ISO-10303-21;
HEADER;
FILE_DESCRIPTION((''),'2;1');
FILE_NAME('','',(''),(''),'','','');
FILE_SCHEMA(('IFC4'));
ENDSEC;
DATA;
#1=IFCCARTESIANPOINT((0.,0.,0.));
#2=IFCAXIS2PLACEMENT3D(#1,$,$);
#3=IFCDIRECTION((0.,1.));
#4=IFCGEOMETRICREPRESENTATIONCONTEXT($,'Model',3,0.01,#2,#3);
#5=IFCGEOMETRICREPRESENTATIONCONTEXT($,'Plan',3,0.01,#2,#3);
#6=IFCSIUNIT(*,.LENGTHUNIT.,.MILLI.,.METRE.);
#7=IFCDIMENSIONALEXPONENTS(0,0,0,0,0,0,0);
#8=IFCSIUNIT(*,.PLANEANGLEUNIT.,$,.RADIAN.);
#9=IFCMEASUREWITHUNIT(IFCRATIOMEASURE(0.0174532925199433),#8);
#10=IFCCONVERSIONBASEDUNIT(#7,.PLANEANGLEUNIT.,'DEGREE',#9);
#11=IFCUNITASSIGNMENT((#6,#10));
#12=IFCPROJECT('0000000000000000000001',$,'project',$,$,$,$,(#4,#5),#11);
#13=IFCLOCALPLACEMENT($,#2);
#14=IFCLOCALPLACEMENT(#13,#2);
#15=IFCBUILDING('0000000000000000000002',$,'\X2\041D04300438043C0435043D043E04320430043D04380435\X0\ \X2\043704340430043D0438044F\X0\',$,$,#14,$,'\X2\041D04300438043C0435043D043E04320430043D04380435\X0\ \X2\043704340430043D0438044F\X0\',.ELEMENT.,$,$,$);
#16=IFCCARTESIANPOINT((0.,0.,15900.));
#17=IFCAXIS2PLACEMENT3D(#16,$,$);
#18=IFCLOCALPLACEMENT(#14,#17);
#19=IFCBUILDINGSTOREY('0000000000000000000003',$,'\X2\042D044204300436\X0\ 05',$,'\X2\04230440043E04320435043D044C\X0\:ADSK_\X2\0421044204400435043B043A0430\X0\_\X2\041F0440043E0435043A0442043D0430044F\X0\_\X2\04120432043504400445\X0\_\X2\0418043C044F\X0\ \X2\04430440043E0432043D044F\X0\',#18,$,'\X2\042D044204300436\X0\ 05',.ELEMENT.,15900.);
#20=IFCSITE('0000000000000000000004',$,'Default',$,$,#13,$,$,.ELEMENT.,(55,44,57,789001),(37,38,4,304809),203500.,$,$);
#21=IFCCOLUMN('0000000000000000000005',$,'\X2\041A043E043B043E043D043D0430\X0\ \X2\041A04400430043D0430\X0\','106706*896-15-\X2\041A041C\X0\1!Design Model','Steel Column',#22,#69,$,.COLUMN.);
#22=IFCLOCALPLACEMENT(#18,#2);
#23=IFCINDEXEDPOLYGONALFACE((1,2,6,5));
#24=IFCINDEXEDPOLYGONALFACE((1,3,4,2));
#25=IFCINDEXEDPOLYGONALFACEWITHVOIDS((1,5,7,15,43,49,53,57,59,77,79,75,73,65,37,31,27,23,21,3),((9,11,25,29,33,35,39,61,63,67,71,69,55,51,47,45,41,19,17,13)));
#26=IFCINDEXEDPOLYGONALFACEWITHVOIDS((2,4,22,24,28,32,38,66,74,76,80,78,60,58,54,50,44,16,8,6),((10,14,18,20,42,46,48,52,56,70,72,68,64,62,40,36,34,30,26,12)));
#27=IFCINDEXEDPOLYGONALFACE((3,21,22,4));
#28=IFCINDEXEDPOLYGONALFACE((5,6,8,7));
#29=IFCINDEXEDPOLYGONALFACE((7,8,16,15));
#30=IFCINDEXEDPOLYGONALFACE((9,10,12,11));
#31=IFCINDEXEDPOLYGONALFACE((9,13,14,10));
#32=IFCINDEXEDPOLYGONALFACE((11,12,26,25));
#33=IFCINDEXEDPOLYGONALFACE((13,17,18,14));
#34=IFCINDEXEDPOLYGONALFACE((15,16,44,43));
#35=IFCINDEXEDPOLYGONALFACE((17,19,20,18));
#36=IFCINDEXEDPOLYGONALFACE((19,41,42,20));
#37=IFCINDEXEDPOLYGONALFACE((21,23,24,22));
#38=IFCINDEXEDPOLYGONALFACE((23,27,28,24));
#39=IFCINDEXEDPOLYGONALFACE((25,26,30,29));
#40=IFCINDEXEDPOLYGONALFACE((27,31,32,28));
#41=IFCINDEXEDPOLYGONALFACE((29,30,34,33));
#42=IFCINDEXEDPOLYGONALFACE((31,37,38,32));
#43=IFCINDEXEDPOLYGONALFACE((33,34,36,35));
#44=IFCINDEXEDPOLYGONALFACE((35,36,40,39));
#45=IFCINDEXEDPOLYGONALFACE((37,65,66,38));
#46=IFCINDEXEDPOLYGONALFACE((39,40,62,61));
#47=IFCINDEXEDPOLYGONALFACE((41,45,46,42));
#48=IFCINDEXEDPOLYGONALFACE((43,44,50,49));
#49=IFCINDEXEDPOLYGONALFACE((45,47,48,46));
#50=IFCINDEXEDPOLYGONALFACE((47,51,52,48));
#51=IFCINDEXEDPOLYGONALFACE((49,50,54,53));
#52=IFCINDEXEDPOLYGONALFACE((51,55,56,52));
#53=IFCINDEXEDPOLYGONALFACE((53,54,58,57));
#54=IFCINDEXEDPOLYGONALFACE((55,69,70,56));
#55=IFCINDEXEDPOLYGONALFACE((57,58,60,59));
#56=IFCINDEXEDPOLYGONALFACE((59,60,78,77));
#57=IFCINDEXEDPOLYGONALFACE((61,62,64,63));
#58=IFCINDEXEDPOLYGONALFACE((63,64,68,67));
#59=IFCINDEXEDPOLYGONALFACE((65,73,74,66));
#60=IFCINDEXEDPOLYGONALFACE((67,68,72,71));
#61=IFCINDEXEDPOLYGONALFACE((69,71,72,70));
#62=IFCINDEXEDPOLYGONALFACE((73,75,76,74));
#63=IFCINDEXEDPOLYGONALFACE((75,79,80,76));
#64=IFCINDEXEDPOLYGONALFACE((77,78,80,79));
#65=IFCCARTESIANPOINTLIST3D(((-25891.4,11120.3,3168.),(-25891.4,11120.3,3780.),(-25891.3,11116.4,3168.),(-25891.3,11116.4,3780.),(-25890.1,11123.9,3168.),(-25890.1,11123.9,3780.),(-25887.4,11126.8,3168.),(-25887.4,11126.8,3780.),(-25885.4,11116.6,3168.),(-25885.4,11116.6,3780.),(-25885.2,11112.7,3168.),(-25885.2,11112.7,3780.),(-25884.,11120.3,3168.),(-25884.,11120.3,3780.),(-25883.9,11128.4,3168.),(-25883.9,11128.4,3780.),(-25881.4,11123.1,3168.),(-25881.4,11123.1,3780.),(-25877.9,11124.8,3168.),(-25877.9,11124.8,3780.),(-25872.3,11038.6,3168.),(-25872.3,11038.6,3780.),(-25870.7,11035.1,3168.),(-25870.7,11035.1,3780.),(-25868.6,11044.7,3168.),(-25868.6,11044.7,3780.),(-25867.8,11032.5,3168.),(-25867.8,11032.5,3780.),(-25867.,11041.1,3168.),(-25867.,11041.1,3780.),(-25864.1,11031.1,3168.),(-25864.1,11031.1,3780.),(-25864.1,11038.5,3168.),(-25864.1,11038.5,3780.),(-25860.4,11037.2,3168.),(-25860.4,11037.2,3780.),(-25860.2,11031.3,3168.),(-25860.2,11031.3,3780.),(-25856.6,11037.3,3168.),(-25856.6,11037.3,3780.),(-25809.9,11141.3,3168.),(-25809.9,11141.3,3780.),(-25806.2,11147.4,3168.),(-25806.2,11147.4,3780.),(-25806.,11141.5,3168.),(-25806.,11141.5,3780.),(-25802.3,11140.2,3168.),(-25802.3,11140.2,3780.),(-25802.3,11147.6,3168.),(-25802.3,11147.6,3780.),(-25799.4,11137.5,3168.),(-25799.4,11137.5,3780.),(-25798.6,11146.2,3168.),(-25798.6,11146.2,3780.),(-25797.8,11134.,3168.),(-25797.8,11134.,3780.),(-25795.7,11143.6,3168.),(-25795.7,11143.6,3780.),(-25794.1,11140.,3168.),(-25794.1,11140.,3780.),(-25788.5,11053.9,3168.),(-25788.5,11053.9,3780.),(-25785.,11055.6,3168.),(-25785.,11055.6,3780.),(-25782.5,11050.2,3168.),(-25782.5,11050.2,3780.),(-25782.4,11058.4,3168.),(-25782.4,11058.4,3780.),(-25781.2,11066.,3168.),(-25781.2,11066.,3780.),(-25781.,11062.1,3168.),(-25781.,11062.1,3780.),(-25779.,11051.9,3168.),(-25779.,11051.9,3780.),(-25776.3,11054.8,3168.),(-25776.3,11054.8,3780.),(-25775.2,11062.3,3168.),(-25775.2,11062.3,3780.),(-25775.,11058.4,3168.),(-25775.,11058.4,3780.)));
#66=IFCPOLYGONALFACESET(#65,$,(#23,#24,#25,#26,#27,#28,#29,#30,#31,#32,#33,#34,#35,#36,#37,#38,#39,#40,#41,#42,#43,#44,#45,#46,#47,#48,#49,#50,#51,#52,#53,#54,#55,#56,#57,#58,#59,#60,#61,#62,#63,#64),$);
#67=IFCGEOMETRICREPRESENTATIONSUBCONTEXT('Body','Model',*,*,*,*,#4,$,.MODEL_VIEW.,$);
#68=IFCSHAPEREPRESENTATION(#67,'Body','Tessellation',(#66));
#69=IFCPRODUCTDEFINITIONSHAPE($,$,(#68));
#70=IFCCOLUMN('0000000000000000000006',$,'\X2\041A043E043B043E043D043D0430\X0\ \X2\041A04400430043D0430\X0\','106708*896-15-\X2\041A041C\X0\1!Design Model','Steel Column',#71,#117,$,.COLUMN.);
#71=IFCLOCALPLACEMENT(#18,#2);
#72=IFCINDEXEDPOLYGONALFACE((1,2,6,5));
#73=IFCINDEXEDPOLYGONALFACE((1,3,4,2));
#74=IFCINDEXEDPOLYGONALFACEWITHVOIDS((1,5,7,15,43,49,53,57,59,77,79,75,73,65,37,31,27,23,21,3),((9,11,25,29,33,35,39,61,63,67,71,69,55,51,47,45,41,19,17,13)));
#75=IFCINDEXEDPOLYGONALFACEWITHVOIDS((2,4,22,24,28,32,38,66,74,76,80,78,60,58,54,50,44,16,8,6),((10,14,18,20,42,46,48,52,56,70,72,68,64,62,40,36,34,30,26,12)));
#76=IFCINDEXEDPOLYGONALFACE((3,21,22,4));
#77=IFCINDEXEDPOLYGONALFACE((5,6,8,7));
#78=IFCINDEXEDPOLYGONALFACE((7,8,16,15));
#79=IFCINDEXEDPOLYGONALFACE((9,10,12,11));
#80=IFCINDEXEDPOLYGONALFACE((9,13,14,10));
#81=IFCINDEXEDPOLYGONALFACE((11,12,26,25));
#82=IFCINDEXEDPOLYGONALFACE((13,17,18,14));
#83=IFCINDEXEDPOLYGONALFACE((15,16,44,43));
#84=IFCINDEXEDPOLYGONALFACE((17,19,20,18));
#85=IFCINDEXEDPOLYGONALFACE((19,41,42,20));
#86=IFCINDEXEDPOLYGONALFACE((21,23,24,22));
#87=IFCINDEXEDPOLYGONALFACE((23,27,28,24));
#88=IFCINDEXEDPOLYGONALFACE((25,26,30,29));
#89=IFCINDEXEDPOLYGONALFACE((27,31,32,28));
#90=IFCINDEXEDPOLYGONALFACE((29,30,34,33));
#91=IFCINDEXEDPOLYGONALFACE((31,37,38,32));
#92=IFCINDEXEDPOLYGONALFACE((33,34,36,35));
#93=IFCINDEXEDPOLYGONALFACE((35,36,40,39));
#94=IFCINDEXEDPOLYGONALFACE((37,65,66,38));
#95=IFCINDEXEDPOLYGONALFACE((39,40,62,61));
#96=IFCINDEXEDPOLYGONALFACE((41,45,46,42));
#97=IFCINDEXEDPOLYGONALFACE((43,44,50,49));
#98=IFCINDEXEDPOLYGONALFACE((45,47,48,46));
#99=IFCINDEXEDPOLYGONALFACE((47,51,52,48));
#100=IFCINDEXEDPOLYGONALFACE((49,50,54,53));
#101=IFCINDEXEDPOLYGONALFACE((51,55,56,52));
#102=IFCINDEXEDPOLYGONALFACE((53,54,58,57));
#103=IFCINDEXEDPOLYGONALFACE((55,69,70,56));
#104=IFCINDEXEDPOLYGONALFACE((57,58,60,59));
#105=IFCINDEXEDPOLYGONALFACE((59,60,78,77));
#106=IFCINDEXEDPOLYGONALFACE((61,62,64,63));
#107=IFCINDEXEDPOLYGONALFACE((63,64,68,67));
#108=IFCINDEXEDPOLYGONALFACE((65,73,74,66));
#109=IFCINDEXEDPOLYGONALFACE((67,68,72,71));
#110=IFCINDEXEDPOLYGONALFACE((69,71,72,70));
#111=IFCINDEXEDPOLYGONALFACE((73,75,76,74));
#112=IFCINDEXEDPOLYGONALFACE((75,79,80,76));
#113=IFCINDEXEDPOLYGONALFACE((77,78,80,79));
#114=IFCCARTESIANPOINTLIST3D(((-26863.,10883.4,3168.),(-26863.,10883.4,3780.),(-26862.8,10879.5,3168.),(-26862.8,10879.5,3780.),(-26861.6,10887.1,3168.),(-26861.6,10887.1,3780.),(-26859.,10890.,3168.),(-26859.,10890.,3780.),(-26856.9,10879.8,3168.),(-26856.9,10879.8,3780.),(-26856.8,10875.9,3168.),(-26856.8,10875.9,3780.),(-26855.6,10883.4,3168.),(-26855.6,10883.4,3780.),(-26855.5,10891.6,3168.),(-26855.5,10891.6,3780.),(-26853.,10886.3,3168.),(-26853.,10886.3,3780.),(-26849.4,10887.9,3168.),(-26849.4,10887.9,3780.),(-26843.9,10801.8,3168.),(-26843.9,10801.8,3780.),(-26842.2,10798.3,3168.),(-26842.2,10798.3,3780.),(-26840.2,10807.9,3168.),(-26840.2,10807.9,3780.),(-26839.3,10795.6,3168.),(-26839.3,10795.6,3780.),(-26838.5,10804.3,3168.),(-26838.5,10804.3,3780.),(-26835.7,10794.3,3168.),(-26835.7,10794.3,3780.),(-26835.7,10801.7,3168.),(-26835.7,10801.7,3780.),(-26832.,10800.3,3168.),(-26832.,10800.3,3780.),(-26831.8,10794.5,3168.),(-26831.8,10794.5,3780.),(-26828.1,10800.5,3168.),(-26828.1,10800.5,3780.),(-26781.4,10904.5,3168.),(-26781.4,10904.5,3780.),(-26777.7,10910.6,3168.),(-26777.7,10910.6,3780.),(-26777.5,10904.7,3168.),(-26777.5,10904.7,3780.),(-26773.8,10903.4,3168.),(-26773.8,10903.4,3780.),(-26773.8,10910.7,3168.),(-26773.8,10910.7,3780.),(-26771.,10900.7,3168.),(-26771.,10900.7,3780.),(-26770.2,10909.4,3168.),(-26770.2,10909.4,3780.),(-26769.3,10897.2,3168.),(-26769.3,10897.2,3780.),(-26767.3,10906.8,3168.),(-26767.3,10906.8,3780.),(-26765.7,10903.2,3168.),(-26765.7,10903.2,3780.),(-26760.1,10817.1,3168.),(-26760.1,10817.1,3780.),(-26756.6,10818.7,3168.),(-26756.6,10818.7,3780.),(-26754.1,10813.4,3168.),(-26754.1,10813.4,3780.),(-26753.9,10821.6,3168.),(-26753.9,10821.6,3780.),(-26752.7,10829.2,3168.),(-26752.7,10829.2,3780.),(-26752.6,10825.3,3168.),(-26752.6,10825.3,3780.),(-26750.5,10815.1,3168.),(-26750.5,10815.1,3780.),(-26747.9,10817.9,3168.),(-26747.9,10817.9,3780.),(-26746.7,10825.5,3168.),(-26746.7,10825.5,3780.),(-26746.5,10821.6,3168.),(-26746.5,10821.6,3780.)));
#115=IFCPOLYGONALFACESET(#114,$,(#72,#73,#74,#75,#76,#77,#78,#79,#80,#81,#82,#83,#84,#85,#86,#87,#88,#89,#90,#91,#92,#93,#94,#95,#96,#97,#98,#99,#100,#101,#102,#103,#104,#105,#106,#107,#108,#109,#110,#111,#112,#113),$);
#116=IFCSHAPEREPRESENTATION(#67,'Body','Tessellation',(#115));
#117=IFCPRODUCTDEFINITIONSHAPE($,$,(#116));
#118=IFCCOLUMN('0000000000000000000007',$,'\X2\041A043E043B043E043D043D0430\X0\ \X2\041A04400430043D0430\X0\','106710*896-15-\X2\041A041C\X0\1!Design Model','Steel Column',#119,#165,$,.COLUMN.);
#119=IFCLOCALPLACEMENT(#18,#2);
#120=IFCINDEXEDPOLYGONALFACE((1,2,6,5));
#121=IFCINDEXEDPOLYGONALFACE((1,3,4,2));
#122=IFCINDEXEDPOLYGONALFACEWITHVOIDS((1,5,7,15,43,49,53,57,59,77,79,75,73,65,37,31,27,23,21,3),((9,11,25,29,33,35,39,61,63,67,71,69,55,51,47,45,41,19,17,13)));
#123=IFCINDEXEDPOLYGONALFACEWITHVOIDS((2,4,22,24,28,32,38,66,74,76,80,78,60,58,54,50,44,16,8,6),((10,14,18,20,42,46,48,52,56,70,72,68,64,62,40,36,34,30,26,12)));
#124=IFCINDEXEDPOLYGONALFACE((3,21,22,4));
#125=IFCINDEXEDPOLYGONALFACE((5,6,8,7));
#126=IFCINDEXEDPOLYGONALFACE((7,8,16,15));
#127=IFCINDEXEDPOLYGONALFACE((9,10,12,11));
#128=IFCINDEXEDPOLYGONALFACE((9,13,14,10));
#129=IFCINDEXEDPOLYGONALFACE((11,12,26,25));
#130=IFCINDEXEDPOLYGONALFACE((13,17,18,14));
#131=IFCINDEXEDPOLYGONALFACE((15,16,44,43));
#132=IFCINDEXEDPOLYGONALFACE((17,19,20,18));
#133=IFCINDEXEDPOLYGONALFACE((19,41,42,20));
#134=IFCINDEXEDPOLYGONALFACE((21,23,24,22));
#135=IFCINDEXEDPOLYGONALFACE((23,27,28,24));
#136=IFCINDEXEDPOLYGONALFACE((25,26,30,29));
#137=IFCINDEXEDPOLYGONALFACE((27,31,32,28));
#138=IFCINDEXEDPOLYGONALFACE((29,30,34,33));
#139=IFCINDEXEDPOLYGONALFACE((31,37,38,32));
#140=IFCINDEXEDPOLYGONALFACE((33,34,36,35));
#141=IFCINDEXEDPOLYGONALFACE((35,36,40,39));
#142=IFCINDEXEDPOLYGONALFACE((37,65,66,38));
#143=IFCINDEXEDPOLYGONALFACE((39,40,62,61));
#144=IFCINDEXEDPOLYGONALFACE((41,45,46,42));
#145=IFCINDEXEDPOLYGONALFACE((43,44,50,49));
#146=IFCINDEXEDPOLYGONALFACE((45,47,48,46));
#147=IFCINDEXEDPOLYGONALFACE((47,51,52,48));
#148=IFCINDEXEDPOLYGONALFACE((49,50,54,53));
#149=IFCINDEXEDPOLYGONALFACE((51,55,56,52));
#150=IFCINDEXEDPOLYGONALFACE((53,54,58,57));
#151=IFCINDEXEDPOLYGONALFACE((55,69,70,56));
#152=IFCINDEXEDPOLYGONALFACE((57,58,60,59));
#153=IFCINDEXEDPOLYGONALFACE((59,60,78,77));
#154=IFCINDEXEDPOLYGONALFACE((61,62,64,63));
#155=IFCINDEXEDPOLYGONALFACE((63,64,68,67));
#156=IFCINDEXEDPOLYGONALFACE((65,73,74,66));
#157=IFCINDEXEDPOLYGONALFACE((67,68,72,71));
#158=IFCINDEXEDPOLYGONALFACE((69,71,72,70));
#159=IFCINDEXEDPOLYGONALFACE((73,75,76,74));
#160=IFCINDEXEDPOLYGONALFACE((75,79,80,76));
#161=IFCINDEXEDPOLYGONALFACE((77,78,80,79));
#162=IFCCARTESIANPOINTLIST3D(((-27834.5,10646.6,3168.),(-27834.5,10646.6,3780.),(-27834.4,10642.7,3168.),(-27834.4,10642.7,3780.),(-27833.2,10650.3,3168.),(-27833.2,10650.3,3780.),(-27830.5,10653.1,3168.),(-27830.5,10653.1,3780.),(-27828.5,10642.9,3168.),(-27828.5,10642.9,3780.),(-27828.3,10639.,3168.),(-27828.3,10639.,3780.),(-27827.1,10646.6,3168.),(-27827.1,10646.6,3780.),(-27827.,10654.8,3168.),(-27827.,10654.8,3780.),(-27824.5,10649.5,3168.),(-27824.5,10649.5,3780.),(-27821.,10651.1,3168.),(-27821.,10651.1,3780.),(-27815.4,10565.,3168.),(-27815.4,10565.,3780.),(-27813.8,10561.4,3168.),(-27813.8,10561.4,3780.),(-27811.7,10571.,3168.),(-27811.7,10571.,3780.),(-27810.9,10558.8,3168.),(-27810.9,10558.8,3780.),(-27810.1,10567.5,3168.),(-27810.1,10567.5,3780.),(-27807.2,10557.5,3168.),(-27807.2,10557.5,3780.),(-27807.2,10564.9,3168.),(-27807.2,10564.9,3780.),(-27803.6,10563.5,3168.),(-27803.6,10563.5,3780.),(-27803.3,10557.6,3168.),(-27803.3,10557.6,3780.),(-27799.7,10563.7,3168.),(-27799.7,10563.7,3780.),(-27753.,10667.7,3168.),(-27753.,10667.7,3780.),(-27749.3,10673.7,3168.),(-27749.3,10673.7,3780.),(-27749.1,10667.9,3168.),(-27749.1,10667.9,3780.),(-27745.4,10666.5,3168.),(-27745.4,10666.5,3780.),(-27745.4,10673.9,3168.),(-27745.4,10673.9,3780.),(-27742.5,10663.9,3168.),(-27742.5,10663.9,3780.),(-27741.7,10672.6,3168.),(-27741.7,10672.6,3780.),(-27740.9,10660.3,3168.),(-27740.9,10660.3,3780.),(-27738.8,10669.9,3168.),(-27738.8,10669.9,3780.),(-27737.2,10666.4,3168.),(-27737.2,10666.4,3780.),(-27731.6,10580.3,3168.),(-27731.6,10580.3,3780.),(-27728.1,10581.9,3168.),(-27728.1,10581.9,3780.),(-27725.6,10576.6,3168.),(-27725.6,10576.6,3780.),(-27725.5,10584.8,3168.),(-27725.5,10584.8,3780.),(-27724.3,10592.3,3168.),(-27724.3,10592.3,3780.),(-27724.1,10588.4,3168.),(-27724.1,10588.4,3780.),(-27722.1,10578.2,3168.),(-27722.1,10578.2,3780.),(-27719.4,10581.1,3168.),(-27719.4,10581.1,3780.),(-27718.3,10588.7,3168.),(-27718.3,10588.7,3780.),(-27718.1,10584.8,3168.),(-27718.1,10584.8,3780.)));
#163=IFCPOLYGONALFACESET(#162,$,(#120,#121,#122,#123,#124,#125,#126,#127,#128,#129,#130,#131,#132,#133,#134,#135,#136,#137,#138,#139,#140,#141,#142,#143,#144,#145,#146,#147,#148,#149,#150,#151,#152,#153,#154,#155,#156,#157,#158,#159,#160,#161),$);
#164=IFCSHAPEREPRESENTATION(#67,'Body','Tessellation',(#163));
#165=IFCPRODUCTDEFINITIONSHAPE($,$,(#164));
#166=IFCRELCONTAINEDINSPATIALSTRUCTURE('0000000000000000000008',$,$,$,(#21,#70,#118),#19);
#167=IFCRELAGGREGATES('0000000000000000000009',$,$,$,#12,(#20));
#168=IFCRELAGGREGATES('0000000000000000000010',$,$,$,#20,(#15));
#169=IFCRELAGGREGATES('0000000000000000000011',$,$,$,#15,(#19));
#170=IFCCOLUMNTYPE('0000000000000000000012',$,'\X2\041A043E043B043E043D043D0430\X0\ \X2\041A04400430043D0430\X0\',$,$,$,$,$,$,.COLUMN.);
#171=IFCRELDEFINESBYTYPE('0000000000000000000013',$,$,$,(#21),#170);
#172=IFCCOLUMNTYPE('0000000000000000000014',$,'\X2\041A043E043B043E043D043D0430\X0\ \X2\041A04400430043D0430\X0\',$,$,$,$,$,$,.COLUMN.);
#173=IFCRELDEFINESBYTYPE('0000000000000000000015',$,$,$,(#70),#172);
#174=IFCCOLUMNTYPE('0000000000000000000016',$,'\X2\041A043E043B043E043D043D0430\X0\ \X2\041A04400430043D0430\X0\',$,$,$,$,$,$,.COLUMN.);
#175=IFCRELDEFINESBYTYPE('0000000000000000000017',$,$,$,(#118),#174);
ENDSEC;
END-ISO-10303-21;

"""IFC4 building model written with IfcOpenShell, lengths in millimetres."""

from ifc_helpers import new_model, entity, si_unit, converted_unit, direction, frame, origin, place, context, subcontext, project, spatial, indexed_curve, outline, extrude, type_object, element, save


model = new_model("IFC4")

# Units and contexts
model_context = context("Model", 3, precision=0.01, world=origin(), true_north=direction((0.0, 1.0)))
plan_context = context("Plan", 3, precision=0.01, world=origin(), true_north=direction((0.0, 1.0)))
body_context = subcontext(model_context, "Body", "Model", "MODEL_VIEW")
ifc_project = project(units=[si_unit("LENGTHUNIT", "METRE", prefix="MILLI"), converted_unit("PLANEANGLEUNIT", "DEGREE", entity("IfcRatioMeasure", 0.0174532925199433), si_unit("PLANEANGLEUNIT", "RADIAN"), dimensions=[0, 0, 0, 0, 0, 0, 0])], contexts=[model_context, plan_context])

# Site, building, storey
site_placement = place(None, origin())
site = spatial("IfcSite", under=ifc_project, at=site_placement, Name="Default", CompositionType="ELEMENT", RefLatitude=(55, 44, 57, 789001), RefLongitude=(37, 38, 4, 304809), RefElevation=203500.0)
building_placement = place(site_placement, origin())
building = spatial("IfcBuilding", under=site, at=building_placement, Name="Наименование здания", LongName="Наименование здания", CompositionType="ELEMENT")
storey_placement = place(building_placement, frame((0.0, 0.0, 15900.0)))
storey = spatial("IfcBuildingStorey", under=building, at=storey_placement, Name="Этаж 05", ObjectType="Уровень:ADSK_Стрелка_Проектная_Вверх_Имя уровня", LongName="Этаж 05", CompositionType="ELEMENT", Elevation=15900.0)

# Columns
column_type_1 = type_object("IfcColumnType", Name="Колонна Крана", PredefinedType="COLUMN")
column_1_placement = place(storey_placement, origin())
element("IfcColumn", 1, at=column_1_placement, inside=storey, type_object=column_type_1, Name="Колонна Крана", Description="106706*896-15-КМ1!Design Model", ObjectType="Steel Column", PredefinedType="COLUMN", context=body_context, shape_type="SweptSolid", body=[
    extrude(outline(indexed_curve([(29.5, -56.8), (33.4, -56.8), (37.0, -55.3), (39.7, -52.6), (41.2, -49.0), (56.8, 29.5), (56.8, 33.4), (55.3, 37.0), (52.6, 39.7), (49.0, 41.2), (-29.5, 56.8), (-33.4, 56.8), (-37.0, 55.3), (-39.7, 52.6), (-41.2, 49.0), (-56.8, -29.5), (-56.8, -33.4), (-55.3, -37.0), (-52.6, -39.7), (-49.0, -41.2), (29.5, -56.8)], self_intersect=False), holes=[indexed_curve([(-43.1, -37.3), (-46.7, -35.8), (-49.5, -33.1), (-51.0, -29.5), (-51.0, -25.5), (-37.3, 43.1), (-35.8, 46.7), (-33.1, 49.5), (-29.5, 51.0), (-25.5, 51.0), (43.1, 37.3), (46.7, 35.8), (49.5, 33.1), (51.0, 29.5), (51.0, 25.5), (37.3, -43.1), (35.8, -46.7), (33.1, -49.5), (29.5, -51.0), (25.5, -51.0), (-43.1, -37.3)], self_intersect=False)]), frame((-25833.2, 11089.3, 3168.0), z_axis=(0.0, 0.0, 1.0), x_axis=(-0.906681, -0.421816, 0.0)), (0.0, 0.0, 1.0), 612.0),
])
column_type_2 = type_object("IfcColumnType", Name="Колонна Крана", PredefinedType="COLUMN")
column_2_placement = place(storey_placement, origin())
element("IfcColumn", 2, at=column_2_placement, inside=storey, type_object=column_type_2, Name="Колонна Крана", Description="106708*896-15-КМ1!Design Model", ObjectType="Steel Column", PredefinedType="COLUMN", context=body_context, shape_type="SweptSolid", body=[
    extrude(outline(indexed_curve([(29.5, -56.8), (33.4, -56.8), (37.0, -55.3), (39.7, -52.6), (41.2, -49.0), (56.8, 29.5), (56.8, 33.4), (55.3, 37.0), (52.6, 39.7), (49.0, 41.2), (-29.5, 56.8), (-33.4, 56.8), (-37.0, 55.3), (-39.7, 52.6), (-41.2, 49.0), (-56.8, -29.5), (-56.8, -33.4), (-55.3, -37.0), (-52.6, -39.7), (-49.0, -41.2), (29.5, -56.8)], self_intersect=False), holes=[indexed_curve([(-43.1, -37.3), (-46.7, -35.8), (-49.5, -33.1), (-51.0, -29.5), (-51.0, -25.5), (-37.3, 43.1), (-35.8, 46.7), (-33.1, 49.5), (-29.5, 51.0), (-25.5, 51.0), (43.1, 37.3), (46.7, 35.8), (49.5, 33.1), (51.0, 29.5), (51.0, 25.5), (37.3, -43.1), (35.8, -46.7), (33.1, -49.5), (29.5, -51.0), (25.5, -51.0), (-43.1, -37.3)], self_intersect=False)]), frame((-26804.8, 10852.5, 3168.0), z_axis=(0.0, 0.0, 1.0), x_axis=(-0.906681, -0.421816, 0.0)), (0.0, 0.0, 1.0), 612.0),
])
column_type_3 = type_object("IfcColumnType", Name="Колонна Крана", PredefinedType="COLUMN")
column_3_placement = place(storey_placement, origin())
element("IfcColumn", 3, at=column_3_placement, inside=storey, type_object=column_type_3, Name="Колонна Крана", Description="106710*896-15-КМ1!Design Model", ObjectType="Steel Column", PredefinedType="COLUMN", context=body_context, shape_type="SweptSolid", body=[
    extrude(outline(indexed_curve([(29.5, -56.8), (33.4, -56.8), (37.0, -55.3), (39.7, -52.6), (41.2, -49.0), (56.8, 29.5), (56.8, 33.4), (55.3, 37.0), (52.6, 39.7), (49.0, 41.2), (-29.5, 56.8), (-33.4, 56.8), (-37.0, 55.3), (-39.7, 52.6), (-41.2, 49.0), (-56.8, -29.5), (-56.8, -33.4), (-55.3, -37.0), (-52.6, -39.7), (-49.0, -41.2), (29.5, -56.8)], self_intersect=False), holes=[indexed_curve([(-43.1, -37.3), (-46.7, -35.8), (-49.5, -33.1), (-51.0, -29.5), (-51.0, -25.5), (-37.3, 43.1), (-35.8, 46.7), (-33.1, 49.5), (-29.5, 51.0), (-25.5, 51.0), (43.1, 37.3), (46.7, 35.8), (49.5, 33.1), (51.0, 29.5), (51.0, 25.5), (37.3, -43.1), (35.8, -46.7), (33.1, -49.5), (29.5, -51.0), (25.5, -51.0), (-43.1, -37.3)], self_intersect=False)]), frame((-27776.3, 10615.7, 3168.0), z_axis=(0.0, 0.0, 1.0), x_axis=(-0.906681, -0.421816, 0.0)), (0.0, 0.0, 1.0), 612.0),
])

save(model, "model.ifc")
